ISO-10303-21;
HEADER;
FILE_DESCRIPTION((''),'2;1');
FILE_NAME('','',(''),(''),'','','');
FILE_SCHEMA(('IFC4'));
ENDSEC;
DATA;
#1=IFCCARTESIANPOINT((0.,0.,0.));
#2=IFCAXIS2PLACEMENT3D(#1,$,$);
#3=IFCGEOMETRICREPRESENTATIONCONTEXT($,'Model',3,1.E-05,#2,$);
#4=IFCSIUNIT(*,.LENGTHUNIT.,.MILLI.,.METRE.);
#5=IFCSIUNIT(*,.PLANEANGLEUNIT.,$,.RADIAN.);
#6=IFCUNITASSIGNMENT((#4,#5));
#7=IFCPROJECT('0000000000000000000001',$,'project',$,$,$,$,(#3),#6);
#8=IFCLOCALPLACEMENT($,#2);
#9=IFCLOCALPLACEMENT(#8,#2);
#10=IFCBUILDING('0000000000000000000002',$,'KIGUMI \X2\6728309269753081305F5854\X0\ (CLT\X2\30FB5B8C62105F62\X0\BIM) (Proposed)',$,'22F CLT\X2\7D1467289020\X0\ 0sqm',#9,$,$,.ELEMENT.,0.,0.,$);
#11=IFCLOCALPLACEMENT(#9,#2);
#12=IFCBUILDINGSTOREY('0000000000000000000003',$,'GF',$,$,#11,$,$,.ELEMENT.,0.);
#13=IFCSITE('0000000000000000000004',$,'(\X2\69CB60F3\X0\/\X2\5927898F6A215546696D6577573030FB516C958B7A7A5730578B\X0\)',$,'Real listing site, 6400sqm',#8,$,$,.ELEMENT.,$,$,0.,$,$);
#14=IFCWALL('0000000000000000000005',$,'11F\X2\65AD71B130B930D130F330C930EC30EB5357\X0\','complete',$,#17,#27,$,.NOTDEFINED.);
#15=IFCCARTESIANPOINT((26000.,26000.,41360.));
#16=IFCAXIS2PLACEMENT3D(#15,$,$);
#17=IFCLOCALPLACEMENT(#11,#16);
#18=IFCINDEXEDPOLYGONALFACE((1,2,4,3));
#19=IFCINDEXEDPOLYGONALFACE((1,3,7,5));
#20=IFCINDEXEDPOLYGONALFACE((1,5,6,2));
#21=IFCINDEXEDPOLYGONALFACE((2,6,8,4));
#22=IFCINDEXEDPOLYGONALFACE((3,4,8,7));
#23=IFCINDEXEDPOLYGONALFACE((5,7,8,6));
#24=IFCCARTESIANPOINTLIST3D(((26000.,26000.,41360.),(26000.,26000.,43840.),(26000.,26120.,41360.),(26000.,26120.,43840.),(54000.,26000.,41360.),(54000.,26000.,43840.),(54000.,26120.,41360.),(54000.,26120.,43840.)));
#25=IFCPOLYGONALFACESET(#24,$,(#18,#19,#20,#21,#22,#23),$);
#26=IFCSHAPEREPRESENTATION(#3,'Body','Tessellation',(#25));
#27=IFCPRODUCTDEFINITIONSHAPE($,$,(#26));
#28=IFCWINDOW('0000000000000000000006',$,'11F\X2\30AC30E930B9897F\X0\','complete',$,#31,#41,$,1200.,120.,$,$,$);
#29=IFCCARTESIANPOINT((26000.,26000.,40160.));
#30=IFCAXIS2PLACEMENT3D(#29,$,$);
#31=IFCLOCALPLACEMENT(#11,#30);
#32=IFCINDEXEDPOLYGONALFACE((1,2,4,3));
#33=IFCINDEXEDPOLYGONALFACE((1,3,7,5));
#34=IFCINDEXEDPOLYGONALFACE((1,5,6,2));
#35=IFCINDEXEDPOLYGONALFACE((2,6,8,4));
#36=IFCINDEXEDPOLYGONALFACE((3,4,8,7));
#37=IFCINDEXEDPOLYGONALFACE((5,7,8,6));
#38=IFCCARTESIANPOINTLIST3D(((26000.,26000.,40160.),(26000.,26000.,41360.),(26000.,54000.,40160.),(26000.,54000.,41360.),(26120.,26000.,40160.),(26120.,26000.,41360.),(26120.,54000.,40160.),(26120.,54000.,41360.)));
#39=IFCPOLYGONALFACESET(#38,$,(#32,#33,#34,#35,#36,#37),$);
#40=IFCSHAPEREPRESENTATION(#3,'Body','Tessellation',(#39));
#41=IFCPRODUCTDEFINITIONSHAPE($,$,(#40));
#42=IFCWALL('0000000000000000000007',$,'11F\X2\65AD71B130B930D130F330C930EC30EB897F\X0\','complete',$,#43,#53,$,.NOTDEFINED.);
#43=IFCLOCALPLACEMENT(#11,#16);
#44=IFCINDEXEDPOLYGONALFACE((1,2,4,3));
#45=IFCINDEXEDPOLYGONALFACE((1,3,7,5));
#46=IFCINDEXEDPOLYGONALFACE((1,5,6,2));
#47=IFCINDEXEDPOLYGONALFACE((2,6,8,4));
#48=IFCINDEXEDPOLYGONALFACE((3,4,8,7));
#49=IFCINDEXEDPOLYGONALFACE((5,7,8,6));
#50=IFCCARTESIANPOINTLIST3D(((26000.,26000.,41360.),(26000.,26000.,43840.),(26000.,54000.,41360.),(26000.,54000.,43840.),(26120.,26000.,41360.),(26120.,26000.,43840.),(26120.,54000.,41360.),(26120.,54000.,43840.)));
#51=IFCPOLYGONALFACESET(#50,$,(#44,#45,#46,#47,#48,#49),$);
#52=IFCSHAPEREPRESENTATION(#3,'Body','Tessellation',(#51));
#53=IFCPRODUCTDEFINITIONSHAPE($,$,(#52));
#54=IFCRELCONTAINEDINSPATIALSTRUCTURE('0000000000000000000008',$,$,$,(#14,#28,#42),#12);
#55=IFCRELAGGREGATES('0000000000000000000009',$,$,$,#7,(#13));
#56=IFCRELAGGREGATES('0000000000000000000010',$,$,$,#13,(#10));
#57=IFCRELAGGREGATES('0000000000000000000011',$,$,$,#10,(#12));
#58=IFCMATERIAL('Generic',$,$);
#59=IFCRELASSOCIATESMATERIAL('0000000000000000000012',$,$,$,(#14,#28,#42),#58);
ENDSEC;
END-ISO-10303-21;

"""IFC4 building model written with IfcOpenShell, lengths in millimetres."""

from ifc_helpers import new_model, si_unit, frame, frame_2d, origin, place, context, project, spatial, rectangle, extrude, material, element, save


model = new_model("IFC4")

# Units and contexts
model_context = context("Model", 3, precision=1e-05, world=origin())
ifc_project = project(units=[si_unit("LENGTHUNIT", "METRE", prefix="MILLI"), si_unit("PLANEANGLEUNIT", "RADIAN")], contexts=[model_context])

# Site, building, storey
site_placement = place(None, origin())
site = spatial("IfcSite", under=ifc_project, at=site_placement, Name="(構想/大規模商業敷地・公開空地型)", ObjectType="Real listing site, 6400sqm", CompositionType="ELEMENT", RefElevation=0.0)
building_placement = place(site_placement, origin())
building = spatial("IfcBuilding", under=site, at=building_placement, Name="KIGUMI 木を極めた塔 (CLT・完成形BIM) (Proposed)", ObjectType="22F CLT純木造 0sqm", CompositionType="ELEMENT", ElevationOfRefHeight=0.0, ElevationOfTerrain=0.0)
storey_placement = place(building_placement, origin())
storey = spatial("IfcBuildingStorey", under=building, at=storey_placement, Name="GF", CompositionType="ELEMENT", Elevation=0.0)

# Shared definitions
ifc_material = material(Name="Generic")

# Wall
wall_1_placement = place(storey_placement, frame((26000.0, 26000.0, 41360.0)))
element("IfcWall", 1, at=wall_1_placement, inside=storey, material=ifc_material, Name="11F断熱スパンドレル南", Description="complete", PredefinedType="NOTDEFINED", context=model_context, shape_type="SweptSolid", body=[
    extrude(rectangle(XDim=28000.0, YDim=120.0, at=frame_2d((14000.0, 60.0))), frame((26000.0, 26000.0, 41360.0)), (0.0, 0.0, 1.0), 2480.0),
])

# Window
window_1_placement = place(storey_placement, frame((26000.0, 26000.0, 40160.0)))
element("IfcWindow", 2, at=window_1_placement, inside=storey, material=ifc_material, Name="11Fガラス西", Description="complete", OverallHeight=1200.0, OverallWidth=120.0, context=model_context, shape_type="SweptSolid", body=[
    extrude(rectangle(XDim=120.0, YDim=28000.0, at=frame_2d((60.0, 14000.0))), frame((26000.0, 26000.0, 40160.0)), (0.0, 0.0, 1.0), 1200.0),
])

# Wall
wall_2_placement = place(storey_placement, frame((26000.0, 26000.0, 41360.0)))
element("IfcWall", 3, at=wall_2_placement, inside=storey, material=ifc_material, Name="11F断熱スパンドレル西", Description="complete", PredefinedType="NOTDEFINED", context=model_context, shape_type="SweptSolid", body=[
    extrude(rectangle(XDim=120.0, YDim=28000.0, at=frame_2d((60.0, 14000.0))), frame((26000.0, 26000.0, 41360.0)), (0.0, 0.0, 1.0), 2480.0),
])

save(model, "model.ifc")
